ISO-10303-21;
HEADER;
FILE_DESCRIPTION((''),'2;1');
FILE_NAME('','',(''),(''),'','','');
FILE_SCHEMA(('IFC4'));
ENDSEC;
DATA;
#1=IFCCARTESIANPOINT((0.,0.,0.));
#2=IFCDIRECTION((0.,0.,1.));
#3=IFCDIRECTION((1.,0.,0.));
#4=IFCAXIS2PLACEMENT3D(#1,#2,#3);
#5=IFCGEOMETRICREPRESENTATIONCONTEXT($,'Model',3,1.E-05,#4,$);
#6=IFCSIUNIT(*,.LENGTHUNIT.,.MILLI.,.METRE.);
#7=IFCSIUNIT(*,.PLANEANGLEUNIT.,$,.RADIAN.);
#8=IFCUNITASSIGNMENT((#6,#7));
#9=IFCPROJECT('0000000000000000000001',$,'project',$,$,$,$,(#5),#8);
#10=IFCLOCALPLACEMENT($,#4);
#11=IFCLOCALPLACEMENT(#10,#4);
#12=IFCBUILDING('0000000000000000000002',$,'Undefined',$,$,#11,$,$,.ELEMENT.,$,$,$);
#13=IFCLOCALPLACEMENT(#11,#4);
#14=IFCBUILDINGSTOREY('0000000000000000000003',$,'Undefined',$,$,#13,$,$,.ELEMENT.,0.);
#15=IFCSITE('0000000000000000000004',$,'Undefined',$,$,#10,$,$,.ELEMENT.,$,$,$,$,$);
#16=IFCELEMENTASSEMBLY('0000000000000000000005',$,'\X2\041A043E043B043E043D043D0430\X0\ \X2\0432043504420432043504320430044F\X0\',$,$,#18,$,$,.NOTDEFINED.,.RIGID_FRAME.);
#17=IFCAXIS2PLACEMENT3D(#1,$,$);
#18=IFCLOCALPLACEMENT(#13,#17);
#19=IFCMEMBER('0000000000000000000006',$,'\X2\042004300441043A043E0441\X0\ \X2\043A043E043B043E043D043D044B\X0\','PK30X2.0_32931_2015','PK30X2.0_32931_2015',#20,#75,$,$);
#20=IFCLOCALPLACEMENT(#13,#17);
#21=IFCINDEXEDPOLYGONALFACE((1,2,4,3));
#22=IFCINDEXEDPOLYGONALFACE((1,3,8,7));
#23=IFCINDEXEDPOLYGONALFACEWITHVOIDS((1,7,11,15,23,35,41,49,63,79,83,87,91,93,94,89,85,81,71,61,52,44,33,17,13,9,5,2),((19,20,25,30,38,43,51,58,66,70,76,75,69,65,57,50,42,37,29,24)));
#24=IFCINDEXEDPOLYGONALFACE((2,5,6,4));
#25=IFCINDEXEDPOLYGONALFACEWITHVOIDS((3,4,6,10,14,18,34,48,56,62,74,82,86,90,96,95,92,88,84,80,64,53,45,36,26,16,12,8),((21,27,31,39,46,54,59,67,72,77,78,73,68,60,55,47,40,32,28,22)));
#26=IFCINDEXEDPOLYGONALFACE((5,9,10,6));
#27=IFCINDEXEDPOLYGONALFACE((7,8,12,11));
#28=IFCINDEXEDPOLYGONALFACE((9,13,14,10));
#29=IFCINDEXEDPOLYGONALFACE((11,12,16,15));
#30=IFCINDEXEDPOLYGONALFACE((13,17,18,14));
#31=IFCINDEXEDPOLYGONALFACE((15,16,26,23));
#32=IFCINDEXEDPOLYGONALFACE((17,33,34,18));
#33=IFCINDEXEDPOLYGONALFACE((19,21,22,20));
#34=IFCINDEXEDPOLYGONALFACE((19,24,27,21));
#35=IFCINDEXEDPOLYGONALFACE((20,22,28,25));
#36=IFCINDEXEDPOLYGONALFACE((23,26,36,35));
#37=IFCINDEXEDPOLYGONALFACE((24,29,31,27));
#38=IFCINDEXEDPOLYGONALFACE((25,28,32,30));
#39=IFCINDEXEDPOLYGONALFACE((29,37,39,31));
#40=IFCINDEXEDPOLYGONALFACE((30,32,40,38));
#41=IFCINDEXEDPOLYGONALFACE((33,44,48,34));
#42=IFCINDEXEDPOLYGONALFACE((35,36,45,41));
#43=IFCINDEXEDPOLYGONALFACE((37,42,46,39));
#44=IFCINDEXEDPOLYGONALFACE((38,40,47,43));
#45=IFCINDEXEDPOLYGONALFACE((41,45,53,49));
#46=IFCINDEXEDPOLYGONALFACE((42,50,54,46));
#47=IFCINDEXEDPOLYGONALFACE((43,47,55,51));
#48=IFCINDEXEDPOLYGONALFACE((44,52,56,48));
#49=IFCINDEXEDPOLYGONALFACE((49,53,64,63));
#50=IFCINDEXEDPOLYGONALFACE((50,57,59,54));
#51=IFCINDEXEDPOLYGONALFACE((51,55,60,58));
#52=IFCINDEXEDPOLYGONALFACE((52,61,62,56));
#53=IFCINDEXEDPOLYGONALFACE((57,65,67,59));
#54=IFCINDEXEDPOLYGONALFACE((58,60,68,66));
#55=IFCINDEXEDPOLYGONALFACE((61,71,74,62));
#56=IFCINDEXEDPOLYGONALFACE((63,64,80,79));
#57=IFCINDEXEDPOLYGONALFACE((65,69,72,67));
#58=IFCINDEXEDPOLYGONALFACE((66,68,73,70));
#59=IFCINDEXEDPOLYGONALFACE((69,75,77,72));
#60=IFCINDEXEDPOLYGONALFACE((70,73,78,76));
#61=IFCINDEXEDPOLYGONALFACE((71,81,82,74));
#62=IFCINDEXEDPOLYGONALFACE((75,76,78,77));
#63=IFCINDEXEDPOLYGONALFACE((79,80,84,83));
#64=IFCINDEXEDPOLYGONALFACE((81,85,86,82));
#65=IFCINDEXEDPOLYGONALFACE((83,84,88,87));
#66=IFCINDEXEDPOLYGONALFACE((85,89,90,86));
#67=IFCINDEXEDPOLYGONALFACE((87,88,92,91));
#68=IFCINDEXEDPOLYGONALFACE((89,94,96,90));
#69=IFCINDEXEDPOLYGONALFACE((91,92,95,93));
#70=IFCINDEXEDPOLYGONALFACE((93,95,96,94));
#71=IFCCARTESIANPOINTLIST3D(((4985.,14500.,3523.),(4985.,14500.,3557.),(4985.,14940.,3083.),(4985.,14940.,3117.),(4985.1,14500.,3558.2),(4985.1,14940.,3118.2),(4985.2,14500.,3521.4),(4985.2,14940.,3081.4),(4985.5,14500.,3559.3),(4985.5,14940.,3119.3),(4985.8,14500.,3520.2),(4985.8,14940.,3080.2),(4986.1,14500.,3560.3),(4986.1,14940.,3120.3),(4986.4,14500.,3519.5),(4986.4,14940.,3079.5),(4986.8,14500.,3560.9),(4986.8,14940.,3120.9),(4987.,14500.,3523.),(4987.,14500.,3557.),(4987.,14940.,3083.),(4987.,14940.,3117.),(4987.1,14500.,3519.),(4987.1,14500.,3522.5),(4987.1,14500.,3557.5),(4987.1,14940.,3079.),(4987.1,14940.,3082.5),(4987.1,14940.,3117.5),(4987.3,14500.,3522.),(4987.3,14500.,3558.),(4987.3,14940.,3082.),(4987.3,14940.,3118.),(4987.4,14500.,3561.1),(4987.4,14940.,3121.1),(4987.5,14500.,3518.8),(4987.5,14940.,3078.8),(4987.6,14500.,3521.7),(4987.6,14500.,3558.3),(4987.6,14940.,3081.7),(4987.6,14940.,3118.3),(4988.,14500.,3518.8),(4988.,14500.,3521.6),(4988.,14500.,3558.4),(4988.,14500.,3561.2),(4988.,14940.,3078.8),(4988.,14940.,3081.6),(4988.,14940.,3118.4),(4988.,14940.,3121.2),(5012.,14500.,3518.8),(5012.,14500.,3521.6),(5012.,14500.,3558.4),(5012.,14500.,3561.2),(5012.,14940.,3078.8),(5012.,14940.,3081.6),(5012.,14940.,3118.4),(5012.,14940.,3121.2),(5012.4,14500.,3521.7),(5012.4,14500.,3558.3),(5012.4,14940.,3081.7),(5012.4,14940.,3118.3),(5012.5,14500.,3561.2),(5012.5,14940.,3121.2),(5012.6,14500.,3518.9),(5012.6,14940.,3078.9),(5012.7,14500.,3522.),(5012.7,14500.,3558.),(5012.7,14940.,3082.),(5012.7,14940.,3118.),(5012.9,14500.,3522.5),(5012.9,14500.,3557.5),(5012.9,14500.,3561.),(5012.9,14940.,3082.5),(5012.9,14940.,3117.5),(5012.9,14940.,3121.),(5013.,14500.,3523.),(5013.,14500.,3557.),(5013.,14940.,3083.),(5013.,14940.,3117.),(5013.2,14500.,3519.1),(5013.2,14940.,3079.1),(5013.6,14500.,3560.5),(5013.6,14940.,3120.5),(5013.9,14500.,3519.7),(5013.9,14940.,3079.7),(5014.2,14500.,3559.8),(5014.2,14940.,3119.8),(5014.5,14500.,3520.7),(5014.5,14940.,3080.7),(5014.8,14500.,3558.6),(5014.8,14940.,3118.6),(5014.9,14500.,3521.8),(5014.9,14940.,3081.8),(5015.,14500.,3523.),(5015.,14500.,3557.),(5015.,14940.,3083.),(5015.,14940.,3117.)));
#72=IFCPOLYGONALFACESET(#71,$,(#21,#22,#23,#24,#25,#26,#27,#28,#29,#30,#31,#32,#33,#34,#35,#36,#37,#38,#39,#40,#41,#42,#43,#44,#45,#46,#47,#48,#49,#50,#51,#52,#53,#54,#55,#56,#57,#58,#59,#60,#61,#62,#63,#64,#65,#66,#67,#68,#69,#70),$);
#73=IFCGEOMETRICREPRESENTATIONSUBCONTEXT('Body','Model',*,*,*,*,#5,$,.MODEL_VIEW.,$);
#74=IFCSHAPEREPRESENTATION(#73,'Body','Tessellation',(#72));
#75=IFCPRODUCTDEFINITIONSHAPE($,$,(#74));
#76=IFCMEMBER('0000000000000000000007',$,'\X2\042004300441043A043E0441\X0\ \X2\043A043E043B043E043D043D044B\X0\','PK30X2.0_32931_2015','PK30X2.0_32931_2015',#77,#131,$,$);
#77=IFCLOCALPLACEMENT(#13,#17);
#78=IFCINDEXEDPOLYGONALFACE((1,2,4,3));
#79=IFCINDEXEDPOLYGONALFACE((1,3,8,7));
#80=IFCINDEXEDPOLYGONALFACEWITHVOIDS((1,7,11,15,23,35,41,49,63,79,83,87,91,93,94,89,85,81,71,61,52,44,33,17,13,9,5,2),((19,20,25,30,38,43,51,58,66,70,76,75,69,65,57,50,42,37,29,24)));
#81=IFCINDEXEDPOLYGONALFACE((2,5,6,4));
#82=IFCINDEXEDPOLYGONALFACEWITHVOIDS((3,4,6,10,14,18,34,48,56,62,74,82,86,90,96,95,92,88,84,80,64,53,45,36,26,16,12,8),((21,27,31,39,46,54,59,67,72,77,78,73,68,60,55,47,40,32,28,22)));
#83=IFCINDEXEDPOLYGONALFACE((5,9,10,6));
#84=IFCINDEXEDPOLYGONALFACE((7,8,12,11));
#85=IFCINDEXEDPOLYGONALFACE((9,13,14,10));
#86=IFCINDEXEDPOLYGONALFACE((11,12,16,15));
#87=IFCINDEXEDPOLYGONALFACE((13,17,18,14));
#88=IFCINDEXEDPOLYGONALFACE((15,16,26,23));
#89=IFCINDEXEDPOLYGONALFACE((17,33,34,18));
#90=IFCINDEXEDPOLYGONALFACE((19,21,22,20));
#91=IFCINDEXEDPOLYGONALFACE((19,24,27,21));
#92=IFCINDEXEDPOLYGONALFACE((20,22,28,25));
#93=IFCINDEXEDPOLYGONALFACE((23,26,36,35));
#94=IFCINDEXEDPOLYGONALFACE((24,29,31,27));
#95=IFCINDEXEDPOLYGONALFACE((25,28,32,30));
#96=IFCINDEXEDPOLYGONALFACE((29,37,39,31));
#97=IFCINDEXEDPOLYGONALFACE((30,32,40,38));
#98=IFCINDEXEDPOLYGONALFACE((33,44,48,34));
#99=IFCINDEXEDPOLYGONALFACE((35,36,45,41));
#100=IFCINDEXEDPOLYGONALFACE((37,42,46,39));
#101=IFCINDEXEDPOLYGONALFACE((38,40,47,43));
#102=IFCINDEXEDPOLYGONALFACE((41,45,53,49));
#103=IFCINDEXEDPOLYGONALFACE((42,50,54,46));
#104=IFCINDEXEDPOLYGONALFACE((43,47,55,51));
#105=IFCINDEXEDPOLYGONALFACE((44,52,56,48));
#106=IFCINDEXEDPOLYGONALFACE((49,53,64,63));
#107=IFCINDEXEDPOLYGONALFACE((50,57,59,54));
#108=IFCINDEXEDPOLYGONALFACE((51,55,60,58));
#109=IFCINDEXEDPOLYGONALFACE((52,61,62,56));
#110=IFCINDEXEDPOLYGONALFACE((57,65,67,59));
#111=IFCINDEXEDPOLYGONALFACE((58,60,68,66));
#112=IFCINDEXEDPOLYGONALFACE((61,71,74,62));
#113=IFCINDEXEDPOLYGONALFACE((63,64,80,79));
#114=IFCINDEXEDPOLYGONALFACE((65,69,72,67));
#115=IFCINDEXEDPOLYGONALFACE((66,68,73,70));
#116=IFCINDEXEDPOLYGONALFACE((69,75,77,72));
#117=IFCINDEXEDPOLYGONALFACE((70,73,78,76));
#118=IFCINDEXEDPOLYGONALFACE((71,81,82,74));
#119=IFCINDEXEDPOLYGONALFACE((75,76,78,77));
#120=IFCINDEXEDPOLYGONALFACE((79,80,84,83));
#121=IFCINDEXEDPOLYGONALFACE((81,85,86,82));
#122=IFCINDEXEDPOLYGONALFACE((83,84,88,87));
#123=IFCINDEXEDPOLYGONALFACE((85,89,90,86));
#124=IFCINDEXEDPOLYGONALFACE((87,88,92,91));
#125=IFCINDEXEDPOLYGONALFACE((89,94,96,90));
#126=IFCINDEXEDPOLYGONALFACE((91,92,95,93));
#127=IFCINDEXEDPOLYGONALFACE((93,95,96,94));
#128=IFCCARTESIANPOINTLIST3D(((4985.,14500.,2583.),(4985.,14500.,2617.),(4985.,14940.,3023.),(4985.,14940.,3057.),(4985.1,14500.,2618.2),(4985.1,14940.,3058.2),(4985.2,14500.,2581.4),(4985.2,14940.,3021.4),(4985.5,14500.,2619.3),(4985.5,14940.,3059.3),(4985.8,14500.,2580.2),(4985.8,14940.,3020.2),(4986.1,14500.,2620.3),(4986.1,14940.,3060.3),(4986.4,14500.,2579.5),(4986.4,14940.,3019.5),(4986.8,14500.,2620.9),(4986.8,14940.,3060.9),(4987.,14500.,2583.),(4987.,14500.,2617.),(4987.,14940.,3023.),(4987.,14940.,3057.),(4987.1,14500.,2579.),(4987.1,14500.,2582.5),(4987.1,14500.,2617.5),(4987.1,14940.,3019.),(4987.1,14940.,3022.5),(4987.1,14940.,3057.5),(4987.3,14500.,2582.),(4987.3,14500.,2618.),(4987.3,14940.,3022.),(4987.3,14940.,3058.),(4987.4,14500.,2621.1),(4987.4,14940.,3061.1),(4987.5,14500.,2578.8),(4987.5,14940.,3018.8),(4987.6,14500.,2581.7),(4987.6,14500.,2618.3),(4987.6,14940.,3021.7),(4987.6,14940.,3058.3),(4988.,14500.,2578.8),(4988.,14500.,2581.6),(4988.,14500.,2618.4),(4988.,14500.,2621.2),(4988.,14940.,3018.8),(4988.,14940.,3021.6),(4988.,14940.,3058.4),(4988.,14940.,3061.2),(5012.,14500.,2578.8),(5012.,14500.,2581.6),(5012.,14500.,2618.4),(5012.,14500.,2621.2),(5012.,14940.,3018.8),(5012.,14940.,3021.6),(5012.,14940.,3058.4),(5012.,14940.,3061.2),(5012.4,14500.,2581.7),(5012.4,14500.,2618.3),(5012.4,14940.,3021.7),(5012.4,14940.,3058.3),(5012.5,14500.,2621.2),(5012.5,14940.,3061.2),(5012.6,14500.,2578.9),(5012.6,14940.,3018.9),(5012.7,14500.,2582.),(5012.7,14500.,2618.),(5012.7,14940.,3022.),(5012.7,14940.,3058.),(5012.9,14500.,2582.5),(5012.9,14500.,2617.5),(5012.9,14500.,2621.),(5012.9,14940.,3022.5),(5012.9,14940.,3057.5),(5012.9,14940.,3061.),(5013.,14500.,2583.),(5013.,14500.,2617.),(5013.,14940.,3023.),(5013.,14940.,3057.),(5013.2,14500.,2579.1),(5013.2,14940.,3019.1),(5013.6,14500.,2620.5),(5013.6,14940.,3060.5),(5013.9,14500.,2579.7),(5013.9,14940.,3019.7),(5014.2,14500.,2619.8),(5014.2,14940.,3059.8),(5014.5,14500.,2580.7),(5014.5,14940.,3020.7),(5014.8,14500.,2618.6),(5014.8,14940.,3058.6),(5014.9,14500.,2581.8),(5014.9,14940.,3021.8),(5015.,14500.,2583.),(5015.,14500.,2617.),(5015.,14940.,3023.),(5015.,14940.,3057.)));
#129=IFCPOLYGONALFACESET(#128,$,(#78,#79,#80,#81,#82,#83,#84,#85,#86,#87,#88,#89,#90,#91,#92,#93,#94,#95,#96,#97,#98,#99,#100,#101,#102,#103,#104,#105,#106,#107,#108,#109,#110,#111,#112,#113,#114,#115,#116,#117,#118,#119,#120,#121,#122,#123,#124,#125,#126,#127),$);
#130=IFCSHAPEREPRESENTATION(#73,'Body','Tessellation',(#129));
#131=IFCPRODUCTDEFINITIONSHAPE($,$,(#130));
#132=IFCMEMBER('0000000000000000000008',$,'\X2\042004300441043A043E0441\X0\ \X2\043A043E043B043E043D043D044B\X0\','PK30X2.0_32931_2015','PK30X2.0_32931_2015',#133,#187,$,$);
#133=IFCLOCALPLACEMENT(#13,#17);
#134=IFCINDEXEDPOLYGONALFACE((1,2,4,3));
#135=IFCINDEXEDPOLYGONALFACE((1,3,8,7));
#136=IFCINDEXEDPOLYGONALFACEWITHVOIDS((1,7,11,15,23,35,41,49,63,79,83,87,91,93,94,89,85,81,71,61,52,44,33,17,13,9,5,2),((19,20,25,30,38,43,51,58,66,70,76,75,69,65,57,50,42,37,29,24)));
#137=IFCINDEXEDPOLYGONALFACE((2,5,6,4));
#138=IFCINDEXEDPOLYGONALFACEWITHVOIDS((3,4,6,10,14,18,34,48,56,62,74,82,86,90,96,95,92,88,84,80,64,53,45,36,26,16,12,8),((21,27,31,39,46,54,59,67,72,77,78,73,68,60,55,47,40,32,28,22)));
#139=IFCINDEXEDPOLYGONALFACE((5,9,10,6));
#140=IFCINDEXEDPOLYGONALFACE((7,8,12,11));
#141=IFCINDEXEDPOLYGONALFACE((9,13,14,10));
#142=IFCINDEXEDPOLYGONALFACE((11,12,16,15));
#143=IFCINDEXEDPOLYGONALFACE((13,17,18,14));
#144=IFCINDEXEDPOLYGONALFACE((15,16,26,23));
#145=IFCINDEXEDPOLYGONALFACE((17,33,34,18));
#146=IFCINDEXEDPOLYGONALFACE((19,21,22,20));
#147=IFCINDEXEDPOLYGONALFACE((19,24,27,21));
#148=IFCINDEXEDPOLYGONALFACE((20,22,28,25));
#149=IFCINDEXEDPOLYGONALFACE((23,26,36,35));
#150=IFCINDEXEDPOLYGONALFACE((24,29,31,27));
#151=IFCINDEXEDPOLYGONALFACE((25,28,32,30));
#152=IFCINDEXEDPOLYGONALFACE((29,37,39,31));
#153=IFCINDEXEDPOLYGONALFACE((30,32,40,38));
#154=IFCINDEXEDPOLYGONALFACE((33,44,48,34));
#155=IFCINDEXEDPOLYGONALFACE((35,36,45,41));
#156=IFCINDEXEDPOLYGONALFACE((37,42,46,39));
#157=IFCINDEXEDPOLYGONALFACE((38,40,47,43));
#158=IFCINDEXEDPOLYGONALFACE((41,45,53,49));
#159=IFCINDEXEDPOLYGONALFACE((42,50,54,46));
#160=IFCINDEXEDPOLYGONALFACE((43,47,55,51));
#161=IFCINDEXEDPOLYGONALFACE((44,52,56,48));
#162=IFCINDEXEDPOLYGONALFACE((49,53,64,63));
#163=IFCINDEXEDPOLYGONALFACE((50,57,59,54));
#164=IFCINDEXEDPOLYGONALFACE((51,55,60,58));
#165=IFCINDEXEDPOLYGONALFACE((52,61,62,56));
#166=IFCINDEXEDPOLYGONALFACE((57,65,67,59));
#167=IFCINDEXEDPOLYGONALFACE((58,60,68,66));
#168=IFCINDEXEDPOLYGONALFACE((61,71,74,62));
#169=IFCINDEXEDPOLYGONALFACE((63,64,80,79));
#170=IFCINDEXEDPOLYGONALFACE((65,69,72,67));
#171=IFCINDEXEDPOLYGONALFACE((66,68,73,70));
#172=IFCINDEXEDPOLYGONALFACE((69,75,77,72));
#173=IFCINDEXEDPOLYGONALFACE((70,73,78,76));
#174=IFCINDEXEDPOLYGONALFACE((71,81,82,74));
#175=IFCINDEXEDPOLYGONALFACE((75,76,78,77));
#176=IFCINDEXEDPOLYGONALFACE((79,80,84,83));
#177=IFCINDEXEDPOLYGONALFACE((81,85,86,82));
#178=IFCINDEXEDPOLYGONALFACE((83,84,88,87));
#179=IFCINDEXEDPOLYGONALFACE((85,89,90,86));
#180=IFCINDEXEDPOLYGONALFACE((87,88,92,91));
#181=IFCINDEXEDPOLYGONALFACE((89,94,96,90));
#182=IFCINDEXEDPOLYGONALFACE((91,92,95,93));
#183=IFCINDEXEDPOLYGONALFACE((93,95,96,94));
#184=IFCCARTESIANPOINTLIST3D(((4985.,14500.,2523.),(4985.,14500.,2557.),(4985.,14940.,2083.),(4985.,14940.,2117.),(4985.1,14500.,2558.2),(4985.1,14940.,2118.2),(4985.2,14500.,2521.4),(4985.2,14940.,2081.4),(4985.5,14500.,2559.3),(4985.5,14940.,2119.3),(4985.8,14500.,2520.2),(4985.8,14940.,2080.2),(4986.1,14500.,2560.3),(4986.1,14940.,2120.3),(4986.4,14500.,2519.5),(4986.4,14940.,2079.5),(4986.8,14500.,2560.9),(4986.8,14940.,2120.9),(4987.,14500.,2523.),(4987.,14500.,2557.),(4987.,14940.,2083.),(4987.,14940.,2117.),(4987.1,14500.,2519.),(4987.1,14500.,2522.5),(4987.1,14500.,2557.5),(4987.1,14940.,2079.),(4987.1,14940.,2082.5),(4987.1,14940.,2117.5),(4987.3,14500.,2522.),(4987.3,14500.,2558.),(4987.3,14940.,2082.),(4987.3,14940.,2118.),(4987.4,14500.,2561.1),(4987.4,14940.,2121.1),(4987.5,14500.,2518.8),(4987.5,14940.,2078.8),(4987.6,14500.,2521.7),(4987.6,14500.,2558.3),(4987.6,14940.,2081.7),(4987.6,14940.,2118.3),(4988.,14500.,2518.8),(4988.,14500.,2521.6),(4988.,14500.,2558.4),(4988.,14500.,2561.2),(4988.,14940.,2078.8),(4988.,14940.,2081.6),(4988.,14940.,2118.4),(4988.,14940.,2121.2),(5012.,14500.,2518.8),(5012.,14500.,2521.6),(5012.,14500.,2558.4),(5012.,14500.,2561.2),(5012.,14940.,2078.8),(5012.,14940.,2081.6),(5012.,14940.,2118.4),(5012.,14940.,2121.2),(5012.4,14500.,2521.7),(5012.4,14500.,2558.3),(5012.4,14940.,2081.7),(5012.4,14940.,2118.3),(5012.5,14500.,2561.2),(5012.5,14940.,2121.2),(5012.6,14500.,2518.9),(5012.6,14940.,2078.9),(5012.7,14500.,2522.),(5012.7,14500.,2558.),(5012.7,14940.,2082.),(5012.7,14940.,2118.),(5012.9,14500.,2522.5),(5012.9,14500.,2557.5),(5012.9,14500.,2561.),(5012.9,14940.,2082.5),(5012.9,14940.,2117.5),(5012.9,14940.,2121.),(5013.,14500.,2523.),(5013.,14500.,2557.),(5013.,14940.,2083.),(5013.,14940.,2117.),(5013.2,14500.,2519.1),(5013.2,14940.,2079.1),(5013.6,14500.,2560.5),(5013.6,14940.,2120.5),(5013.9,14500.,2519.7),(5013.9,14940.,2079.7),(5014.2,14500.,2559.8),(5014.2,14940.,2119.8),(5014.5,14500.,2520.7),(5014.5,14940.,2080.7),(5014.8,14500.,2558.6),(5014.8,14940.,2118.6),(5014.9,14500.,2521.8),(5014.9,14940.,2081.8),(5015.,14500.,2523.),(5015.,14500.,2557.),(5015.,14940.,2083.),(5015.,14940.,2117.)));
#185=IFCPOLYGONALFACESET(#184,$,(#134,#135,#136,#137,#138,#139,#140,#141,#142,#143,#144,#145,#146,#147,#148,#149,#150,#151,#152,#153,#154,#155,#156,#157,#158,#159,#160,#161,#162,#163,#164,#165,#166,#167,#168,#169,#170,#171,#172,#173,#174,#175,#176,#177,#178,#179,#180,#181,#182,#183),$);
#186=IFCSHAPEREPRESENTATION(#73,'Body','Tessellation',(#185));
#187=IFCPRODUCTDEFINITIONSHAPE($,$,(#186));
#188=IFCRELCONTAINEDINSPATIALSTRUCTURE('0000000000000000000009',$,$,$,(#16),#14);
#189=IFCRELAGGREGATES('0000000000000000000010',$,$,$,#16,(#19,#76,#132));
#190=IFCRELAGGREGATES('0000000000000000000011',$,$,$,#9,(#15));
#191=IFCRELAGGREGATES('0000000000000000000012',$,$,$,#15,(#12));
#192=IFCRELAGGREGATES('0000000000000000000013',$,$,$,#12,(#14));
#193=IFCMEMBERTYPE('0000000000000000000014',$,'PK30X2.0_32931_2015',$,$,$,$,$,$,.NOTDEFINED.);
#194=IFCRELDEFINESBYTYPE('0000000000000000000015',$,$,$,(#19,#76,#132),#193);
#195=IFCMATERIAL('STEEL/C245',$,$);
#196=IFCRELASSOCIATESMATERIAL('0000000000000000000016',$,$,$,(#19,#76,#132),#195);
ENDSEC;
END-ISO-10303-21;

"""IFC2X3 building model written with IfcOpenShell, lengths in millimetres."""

from ifc_helpers import new_model, si_unit, frame, origin_with_axes, origin_2d_with_axis, place, context, subcontext, project, spatial, hollow_rectangle, extrude, clip, halfspace, material, type_object, element, aggregate, save


model = new_model("IFC2X3")

# Units and contexts
model_context = context("Model", 3, precision=1e-05, world=origin_with_axes())
body_context = subcontext(model_context, "Body", "Model", "MODEL_VIEW")
ifc_project = project(units=[si_unit("LENGTHUNIT", "METRE", prefix="MILLI"), si_unit("PLANEANGLEUNIT", "RADIAN")], contexts=[model_context])

# Site, building, storey
site_placement = place(None, origin_with_axes())
site = spatial("IfcSite", under=ifc_project, at=site_placement, Name="Undefined", CompositionType="ELEMENT")
building_placement = place(site_placement, origin_with_axes())
building = spatial("IfcBuilding", under=site, at=building_placement, Name="Undefined", CompositionType="ELEMENT")
storey_placement = place(building_placement, origin_with_axes())
storey = spatial("IfcBuildingStorey", under=building, at=storey_placement, Name="Undefined", CompositionType="ELEMENT", Elevation=0.0)

# Shared definitions
ifc_material_1 = material(Name="STEEL/C245")

# Element assembly, members
assembly_1_placement = place(storey_placement, origin_with_axes())
assembly_1 = element("IfcElementAssembly", 1, at=assembly_1_placement, inside=storey, Name="Колонна ветвевая", AssemblyPlace="NOTDEFINED", PredefinedType="RIGID_FRAME")
member_type_1 = type_object("IfcMemberType", Name="PK30X2.0_32931_2015", PredefinedType="NOTDEFINED")
member_1_placement = place(assembly_1_placement, frame((5000.0, 14470.0, 3570.0), z_axis=(0.0, -0.707107, -0.707107), x_axis=(0.0, 0.707107, -0.707107)))
member_1 = element("IfcMember", 2, at=member_1_placement, type_object=member_type_1, material=ifc_material_1, Name="Раскос колонны", Description="PK30X2.0_32931_2015", ObjectType="PK30X2.0_32931_2015", context=body_context, shape_type="Clipping", body=[
    clip(clip(extrude(hollow_rectangle(XDim=30.0, YDim=30.0, WallThickness=2.0, InnerFilletRadius=1.0, OuterFilletRadius=3.0, at=origin_2d_with_axis()), frame((695.0, 0.0, 0.0), z_axis=(-1.0, 0.0, 0.0), x_axis=(0.0, -1.0, 0.0)), (0.0, 0.0, 1.0), 682.9), halfspace(frame((629.0, 0.0, -35.7), z_axis=(-0.707107, 0.0, 0.707107), x_axis=(0.707107, 0.0, 0.707107)), True)), halfspace(frame((65.2, 0.0, 22.8), z_axis=(-0.707107, 0.0, 0.707107), x_axis=(0.707107, 0.0, 0.707107)), False)),
])
member_2_placement = place(assembly_1_placement, frame((5000.0, 14470.0, 2570.0), z_axis=(0.0, -0.707107, 0.707107), x_axis=(0.0, 0.707107, 0.707107)))
member_2 = element("IfcMember", 3, at=member_2_placement, type_object=member_type_1, material=ifc_material_1, Name="Раскос колонны", Description="PK30X2.0_32931_2015", ObjectType="PK30X2.0_32931_2015", context=body_context, shape_type="Clipping", body=[
    clip(clip(extrude(hollow_rectangle(XDim=30.0, YDim=30.0, WallThickness=2.0, InnerFilletRadius=1.0, OuterFilletRadius=3.0, at=origin_2d_with_axis()), frame((695.0, 0.0, 0.0), z_axis=(-1.0, 0.0, 0.0), x_axis=(0.0, -1.0, 0.0)), (0.0, 0.0, 1.0), 682.9), halfspace(frame((629.0, 0.0, -35.7), z_axis=(-0.707107, 0.0, 0.707107), x_axis=(0.707107, 0.0, 0.707107)), True)), halfspace(frame((65.2, 0.0, 22.8), z_axis=(-0.707107, 0.0, 0.707107), x_axis=(0.707107, 0.0, 0.707107)), False)),
])
member_3_placement = place(assembly_1_placement, frame((5000.0, 14470.0, 2570.0), z_axis=(0.0, -0.707107, -0.707107), x_axis=(0.0, 0.707107, -0.707107)))
member_3 = element("IfcMember", 4, at=member_3_placement, type_object=member_type_1, material=ifc_material_1, Name="Раскос колонны", Description="PK30X2.0_32931_2015", ObjectType="PK30X2.0_32931_2015", context=body_context, shape_type="Clipping", body=[
    clip(clip(extrude(hollow_rectangle(XDim=30.0, YDim=30.0, WallThickness=2.0, InnerFilletRadius=1.0, OuterFilletRadius=3.0, at=origin_2d_with_axis()), frame((695.0, 0.0, 0.0), z_axis=(-1.0, 0.0, 0.0), x_axis=(0.0, -1.0, 0.0)), (0.0, 0.0, 1.0), 682.9), halfspace(frame((629.0, 0.0, -35.7), z_axis=(-0.707107, 0.0, 0.707107), x_axis=(0.707107, 0.0, 0.707107)), True)), halfspace(frame((65.2, 0.0, 22.8), z_axis=(-0.707107, 0.0, 0.707107), x_axis=(0.707107, 0.0, 0.707107)), False)),
])

aggregate(assembly_1, [member_1, member_2, member_3])

save(model, "model.ifc")
